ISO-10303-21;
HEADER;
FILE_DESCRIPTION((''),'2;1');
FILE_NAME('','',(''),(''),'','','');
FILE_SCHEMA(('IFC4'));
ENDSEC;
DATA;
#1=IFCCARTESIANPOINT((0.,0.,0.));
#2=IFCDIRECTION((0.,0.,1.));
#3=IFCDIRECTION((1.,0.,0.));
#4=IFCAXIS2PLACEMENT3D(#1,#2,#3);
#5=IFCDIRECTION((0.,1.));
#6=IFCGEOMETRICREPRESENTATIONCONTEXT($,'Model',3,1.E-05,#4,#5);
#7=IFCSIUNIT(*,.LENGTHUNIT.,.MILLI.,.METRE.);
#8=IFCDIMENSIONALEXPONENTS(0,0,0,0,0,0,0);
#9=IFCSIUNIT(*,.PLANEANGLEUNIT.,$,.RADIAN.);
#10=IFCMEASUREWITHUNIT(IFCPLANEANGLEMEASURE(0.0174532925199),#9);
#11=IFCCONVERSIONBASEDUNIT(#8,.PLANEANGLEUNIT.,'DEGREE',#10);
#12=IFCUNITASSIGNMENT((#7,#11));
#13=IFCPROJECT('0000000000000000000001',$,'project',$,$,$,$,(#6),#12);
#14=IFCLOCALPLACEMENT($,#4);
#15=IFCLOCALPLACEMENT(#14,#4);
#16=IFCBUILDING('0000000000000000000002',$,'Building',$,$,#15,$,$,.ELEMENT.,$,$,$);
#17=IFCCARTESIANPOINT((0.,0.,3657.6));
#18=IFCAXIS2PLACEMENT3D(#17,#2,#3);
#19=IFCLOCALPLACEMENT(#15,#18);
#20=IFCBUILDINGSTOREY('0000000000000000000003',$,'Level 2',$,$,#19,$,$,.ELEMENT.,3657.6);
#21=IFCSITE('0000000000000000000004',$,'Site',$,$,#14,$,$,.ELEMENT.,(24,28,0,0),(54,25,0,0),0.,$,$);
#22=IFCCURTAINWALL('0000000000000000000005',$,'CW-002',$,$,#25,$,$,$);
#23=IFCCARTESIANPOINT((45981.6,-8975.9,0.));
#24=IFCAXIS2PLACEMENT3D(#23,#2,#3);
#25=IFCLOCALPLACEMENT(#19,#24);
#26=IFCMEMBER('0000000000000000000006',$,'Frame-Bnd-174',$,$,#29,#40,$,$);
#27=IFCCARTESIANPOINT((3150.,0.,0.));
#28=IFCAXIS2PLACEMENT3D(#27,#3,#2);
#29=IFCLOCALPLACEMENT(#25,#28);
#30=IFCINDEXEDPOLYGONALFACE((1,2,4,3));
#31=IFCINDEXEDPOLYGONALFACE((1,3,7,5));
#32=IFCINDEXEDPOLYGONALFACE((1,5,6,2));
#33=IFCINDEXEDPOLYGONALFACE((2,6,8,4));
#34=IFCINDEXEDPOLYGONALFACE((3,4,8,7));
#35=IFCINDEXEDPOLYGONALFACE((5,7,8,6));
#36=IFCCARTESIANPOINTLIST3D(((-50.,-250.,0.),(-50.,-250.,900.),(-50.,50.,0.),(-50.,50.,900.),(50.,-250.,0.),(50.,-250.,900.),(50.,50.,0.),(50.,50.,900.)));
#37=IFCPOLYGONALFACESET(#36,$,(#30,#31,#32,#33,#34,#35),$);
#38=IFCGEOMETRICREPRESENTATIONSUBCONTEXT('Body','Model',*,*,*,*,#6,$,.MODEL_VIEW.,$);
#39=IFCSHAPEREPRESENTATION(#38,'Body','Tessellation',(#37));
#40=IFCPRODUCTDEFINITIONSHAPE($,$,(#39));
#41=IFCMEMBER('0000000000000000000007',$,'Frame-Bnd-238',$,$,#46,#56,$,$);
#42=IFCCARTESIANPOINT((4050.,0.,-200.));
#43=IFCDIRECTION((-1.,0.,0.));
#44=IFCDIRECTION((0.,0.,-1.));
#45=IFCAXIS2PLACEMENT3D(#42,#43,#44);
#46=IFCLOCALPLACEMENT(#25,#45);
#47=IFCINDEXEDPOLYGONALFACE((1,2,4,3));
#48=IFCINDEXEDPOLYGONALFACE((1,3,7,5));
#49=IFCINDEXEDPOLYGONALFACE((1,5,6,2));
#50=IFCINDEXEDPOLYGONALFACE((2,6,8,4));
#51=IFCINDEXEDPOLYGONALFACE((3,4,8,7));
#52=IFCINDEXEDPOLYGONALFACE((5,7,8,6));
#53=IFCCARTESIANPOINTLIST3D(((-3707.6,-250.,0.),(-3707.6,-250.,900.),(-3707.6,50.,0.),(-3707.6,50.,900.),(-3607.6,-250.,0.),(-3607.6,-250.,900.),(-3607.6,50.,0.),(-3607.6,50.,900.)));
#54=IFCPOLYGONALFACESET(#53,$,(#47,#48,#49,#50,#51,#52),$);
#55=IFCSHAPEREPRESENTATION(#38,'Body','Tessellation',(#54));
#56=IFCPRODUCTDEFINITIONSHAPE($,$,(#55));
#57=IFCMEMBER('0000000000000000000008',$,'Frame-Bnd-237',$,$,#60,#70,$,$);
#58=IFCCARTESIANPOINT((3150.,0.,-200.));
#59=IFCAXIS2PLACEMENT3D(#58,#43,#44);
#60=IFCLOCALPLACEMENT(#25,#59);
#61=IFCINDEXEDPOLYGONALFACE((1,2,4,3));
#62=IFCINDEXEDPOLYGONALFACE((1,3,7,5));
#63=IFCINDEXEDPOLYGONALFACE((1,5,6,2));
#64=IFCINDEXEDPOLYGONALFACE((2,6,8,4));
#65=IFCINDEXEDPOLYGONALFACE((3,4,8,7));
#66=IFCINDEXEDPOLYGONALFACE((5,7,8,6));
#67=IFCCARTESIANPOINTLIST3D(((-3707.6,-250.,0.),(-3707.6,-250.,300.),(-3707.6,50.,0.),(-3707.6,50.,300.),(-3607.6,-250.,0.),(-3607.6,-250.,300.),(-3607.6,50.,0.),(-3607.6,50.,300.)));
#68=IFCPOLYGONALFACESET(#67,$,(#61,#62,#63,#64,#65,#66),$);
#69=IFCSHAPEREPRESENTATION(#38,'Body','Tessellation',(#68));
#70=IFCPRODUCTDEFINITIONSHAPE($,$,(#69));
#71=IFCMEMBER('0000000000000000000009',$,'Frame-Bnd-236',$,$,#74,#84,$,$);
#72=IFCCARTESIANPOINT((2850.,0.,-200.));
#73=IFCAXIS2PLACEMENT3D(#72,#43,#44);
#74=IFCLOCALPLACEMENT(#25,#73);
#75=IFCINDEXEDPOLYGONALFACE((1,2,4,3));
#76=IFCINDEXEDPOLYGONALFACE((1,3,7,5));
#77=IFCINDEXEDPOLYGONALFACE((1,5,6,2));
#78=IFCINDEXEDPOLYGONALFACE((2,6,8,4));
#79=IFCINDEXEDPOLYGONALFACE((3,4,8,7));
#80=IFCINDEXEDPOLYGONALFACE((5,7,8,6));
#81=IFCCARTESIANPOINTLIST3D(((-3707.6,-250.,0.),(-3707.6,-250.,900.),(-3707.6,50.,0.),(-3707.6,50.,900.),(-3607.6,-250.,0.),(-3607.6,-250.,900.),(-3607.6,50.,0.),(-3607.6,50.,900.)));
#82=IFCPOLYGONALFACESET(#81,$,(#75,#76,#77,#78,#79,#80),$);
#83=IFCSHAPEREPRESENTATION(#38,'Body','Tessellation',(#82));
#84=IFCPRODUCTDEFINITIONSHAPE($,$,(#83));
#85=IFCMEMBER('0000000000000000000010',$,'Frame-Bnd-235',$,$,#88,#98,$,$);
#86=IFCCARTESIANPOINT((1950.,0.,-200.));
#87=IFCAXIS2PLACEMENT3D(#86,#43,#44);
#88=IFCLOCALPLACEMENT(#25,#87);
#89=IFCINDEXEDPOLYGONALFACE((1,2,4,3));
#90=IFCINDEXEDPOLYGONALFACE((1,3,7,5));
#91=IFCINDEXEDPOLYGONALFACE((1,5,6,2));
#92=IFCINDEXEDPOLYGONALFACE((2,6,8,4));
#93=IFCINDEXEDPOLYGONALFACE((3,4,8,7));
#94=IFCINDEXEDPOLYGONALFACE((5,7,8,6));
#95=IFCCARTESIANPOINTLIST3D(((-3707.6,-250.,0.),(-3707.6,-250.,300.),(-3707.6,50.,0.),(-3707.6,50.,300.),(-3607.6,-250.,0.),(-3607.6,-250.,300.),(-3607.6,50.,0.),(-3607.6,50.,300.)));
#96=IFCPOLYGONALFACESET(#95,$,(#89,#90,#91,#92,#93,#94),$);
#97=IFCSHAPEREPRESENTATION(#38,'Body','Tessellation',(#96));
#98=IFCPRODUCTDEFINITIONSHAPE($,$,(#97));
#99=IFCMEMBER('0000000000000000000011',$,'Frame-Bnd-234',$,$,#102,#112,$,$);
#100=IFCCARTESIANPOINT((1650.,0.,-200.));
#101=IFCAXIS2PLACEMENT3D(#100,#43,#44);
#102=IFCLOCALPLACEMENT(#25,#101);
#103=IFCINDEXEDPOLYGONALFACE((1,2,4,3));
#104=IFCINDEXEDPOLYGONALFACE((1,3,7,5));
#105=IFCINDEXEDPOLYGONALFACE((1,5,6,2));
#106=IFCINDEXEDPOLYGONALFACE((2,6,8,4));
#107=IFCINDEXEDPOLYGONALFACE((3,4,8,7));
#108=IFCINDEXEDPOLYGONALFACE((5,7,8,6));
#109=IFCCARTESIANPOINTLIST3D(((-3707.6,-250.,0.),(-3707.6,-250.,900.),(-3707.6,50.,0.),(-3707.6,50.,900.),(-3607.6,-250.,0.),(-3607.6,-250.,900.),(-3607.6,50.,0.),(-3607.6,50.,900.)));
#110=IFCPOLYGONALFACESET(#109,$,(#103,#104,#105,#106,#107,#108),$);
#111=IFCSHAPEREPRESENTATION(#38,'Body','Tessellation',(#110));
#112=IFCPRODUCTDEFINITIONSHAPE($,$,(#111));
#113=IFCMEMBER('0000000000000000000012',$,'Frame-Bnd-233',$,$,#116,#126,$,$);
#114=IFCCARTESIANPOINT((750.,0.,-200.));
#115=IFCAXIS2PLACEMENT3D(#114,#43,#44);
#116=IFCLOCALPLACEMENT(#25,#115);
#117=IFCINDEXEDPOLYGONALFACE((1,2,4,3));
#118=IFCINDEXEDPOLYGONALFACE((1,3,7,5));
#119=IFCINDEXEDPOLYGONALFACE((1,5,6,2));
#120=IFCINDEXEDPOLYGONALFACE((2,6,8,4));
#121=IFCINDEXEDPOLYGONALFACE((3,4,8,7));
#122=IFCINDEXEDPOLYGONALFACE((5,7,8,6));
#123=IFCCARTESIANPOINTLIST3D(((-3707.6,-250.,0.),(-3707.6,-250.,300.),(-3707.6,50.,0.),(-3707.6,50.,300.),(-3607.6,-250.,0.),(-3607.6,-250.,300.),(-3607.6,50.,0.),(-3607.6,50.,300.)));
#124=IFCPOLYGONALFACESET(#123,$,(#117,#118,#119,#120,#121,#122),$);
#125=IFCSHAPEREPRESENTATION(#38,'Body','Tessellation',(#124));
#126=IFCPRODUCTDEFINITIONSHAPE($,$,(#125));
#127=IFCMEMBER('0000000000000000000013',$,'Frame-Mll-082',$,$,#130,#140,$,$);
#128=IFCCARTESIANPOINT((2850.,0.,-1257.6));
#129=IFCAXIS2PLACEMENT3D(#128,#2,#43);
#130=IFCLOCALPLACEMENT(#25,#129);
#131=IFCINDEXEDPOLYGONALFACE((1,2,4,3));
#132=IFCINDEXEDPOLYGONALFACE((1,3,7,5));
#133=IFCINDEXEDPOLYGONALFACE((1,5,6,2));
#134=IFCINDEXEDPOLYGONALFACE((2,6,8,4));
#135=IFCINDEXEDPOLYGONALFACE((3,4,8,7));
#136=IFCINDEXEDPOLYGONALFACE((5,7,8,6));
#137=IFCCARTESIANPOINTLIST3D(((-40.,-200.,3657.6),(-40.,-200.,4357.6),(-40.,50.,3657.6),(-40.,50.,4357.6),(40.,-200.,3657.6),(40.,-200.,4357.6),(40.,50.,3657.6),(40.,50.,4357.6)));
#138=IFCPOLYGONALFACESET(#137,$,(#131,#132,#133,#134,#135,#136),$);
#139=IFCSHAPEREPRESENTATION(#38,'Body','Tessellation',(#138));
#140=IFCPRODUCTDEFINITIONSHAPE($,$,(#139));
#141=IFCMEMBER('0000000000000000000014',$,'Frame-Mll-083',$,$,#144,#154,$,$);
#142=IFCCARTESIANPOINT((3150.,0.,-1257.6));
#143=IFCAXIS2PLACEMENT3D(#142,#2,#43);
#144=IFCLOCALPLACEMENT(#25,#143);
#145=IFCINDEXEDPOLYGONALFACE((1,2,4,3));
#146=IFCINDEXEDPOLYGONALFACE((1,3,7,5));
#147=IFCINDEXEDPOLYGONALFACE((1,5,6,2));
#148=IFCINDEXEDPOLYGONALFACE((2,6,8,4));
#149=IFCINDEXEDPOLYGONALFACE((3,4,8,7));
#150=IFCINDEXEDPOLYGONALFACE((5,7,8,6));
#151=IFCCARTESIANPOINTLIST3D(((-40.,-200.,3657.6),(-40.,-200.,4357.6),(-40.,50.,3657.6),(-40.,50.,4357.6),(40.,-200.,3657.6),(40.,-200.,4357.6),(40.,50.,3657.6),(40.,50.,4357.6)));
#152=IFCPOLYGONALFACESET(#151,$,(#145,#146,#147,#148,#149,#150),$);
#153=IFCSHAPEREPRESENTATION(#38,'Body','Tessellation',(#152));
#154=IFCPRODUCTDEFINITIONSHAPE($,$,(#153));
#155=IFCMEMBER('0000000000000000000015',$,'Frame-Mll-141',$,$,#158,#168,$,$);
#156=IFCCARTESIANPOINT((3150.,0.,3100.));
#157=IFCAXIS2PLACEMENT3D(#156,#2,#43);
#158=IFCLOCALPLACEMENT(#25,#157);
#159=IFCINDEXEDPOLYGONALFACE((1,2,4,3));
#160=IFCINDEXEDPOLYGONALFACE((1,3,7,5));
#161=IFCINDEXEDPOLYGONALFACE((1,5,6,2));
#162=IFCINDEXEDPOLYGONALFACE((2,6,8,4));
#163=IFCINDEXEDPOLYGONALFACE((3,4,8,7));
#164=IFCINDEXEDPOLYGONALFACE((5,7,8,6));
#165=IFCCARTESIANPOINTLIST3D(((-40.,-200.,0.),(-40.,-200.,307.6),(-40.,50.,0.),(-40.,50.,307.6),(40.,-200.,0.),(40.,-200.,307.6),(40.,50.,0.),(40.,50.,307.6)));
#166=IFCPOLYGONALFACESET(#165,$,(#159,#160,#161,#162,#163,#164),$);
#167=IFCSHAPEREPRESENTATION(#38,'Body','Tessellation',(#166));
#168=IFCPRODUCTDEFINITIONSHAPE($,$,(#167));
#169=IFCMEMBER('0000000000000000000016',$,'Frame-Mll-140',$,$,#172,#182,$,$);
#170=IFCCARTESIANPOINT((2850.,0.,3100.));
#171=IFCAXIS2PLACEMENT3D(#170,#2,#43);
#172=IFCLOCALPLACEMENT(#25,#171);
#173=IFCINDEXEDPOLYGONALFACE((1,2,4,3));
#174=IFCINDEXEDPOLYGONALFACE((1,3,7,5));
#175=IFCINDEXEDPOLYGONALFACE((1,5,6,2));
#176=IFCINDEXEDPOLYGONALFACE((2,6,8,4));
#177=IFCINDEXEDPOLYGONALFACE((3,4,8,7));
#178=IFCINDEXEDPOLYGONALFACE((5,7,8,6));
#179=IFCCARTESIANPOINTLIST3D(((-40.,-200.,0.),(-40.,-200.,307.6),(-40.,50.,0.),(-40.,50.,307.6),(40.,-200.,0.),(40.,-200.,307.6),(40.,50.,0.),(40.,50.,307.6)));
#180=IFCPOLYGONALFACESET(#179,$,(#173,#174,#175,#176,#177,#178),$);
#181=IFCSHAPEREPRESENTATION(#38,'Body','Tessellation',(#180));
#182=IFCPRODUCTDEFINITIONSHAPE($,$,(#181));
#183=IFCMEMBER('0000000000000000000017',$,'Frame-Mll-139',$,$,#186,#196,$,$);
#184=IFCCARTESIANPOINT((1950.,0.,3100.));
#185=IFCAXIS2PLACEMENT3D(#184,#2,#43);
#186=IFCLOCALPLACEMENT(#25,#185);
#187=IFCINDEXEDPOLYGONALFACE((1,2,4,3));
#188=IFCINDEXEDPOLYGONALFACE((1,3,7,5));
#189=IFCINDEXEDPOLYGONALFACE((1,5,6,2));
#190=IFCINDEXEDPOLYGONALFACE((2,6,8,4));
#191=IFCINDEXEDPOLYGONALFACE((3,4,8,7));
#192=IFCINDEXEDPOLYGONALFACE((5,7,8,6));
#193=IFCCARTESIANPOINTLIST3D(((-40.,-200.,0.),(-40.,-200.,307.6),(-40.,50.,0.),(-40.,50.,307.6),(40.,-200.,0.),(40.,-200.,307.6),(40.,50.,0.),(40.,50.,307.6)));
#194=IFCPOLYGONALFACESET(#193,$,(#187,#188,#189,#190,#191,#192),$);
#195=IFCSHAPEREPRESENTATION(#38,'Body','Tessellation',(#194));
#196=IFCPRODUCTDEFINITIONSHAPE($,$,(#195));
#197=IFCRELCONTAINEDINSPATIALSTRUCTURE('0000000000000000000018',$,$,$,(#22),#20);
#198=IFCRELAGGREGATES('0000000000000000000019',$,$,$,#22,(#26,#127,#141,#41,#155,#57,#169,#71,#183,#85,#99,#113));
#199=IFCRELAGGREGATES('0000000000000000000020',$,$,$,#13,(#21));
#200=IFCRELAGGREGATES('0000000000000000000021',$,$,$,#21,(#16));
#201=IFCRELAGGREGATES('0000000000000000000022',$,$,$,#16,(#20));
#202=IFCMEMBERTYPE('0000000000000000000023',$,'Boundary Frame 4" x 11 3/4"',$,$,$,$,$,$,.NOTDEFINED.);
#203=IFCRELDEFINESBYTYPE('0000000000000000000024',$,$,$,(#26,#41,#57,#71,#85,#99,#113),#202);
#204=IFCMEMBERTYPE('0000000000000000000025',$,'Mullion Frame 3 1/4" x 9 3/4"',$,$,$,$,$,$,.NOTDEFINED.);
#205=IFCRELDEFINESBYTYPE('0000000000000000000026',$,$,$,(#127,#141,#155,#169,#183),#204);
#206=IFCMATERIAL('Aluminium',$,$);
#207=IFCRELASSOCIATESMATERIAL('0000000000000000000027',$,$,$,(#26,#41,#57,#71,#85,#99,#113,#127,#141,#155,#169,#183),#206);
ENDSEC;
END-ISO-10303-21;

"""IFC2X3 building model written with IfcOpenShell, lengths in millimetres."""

from ifc_helpers import new_model, entity, si_unit, converted_unit, direction, frame, origin_with_axes, place, context, subcontext, project, spatial, polyline, outline, extrude, material, type_object, element, aggregate, save


model = new_model("IFC2X3")

# Units and contexts
model_context = context("Model", 3, precision=1e-05, world=origin_with_axes(), true_north=direction((0.0, 1.0)))
body_context = subcontext(model_context, "Body", "Model", "MODEL_VIEW")
ifc_project = project(units=[si_unit("LENGTHUNIT", "METRE", prefix="MILLI"), converted_unit("PLANEANGLEUNIT", "DEGREE", entity("IfcPlaneAngleMeasure", 0.0174532925199), si_unit("PLANEANGLEUNIT", "RADIAN"), dimensions=[0, 0, 0, 0, 0, 0, 0])], contexts=[model_context])

# Site, building, storey
site_placement = place(None, origin_with_axes())
site = spatial("IfcSite", under=ifc_project, at=site_placement, Name="Site", CompositionType="ELEMENT", RefLatitude=(24, 28, 0, 0), RefLongitude=(54, 25, 0, 0), RefElevation=0.0)
building_placement = place(site_placement, origin_with_axes())
building = spatial("IfcBuilding", under=site, at=building_placement, Name="Building", CompositionType="ELEMENT")
storey_placement = place(building_placement, frame((0.0, 0.0, 3657.6), z_axis=(0.0, 0.0, 1.0), x_axis=(1.0, 0.0, 0.0)))
storey = spatial("IfcBuildingStorey", under=building, at=storey_placement, Name="Level 2", CompositionType="ELEMENT", Elevation=3657.6)

# Curtain wall, members
curtain_wall_placement = place(storey_placement, frame((45981.6, -8975.9, 0.0), z_axis=(0.0, 0.0, 1.0), x_axis=(1.0, 0.0, 0.0)))
curtain_wall = element("IfcCurtainWall", 1, at=curtain_wall_placement, inside=storey, Name="CW-002")
ifc_material_1 = material(Name="Aluminium")
member_type_1 = type_object("IfcMemberType", Name="Boundary Frame 4\" x 11 3/4\"", PredefinedType="NOTDEFINED")
member_1_placement = place(curtain_wall_placement, frame((3150.0, 0.0, 0.0), z_axis=(1.0, 0.0, 0.0), x_axis=(0.0, 0.0, 1.0)))
member_1 = element("IfcMember", 2, at=member_1_placement, type_object=member_type_1, material=ifc_material_1, Name="Frame-Bnd-174", context=body_context, shape_type="SweptSolid", body=[
    extrude(outline(polyline([(-250.0, -50.0), (50.0, -50.0), (50.0, 50.0), (-250.0, 50.0), (-250.0, -50.0)])), frame((0.0, 0.0, 0.0), z_axis=(0.0, 0.0, 1.0), x_axis=(0.0, 1.0, 0.0)), (0.0, 0.0, 1.0), 900.0),
])
member_2_placement = place(curtain_wall_placement, frame((4050.0, 0.0, -200.0), z_axis=(-1.0, 0.0, 0.0), x_axis=(0.0, 0.0, -1.0)))
member_2 = element("IfcMember", 3, at=member_2_placement, type_object=member_type_1, material=ifc_material_1, Name="Frame-Bnd-238", context=body_context, shape_type="SweptSolid", body=[
    extrude(outline(polyline([(250.0, -3607.6), (-50.0, -3607.6), (-50.0, -3707.6), (250.0, -3707.6), (250.0, -3607.6)])), frame((0.0, 0.0, 0.0), z_axis=(0.0, 0.0, 1.0), x_axis=(0.0, -1.0, 0.0)), (0.0, 0.0, 1.0), 900.0),
])
member_3_placement = place(curtain_wall_placement, frame((3150.0, 0.0, -200.0), z_axis=(-1.0, 0.0, 0.0), x_axis=(0.0, 0.0, -1.0)))
member_3 = element("IfcMember", 4, at=member_3_placement, type_object=member_type_1, material=ifc_material_1, Name="Frame-Bnd-237", context=body_context, shape_type="SweptSolid", body=[
    extrude(outline(polyline([(250.0, -3607.6), (-50.0, -3607.6), (-50.0, -3707.6), (250.0, -3707.6), (250.0, -3607.6)])), frame((0.0, 0.0, 0.0), z_axis=(0.0, 0.0, 1.0), x_axis=(0.0, -1.0, 0.0)), (0.0, 0.0, 1.0), 300.0),
])
member_4_placement = place(curtain_wall_placement, frame((2850.0, 0.0, -200.0), z_axis=(-1.0, 0.0, 0.0), x_axis=(0.0, 0.0, -1.0)))
member_4 = element("IfcMember", 5, at=member_4_placement, type_object=member_type_1, material=ifc_material_1, Name="Frame-Bnd-236", context=body_context, shape_type="SweptSolid", body=[
    extrude(outline(polyline([(250.0, -3607.6), (-50.0, -3607.6), (-50.0, -3707.6), (250.0, -3707.6), (250.0, -3607.6)])), frame((0.0, 0.0, 0.0), z_axis=(0.0, 0.0, 1.0), x_axis=(0.0, -1.0, 0.0)), (0.0, 0.0, 1.0), 900.0),
])
member_5_placement = place(curtain_wall_placement, frame((1950.0, 0.0, -200.0), z_axis=(-1.0, 0.0, 0.0), x_axis=(0.0, 0.0, -1.0)))
member_5 = element("IfcMember", 6, at=member_5_placement, type_object=member_type_1, material=ifc_material_1, Name="Frame-Bnd-235", context=body_context, shape_type="SweptSolid", body=[
    extrude(outline(polyline([(250.0, -3607.6), (-50.0, -3607.6), (-50.0, -3707.6), (250.0, -3707.6), (250.0, -3607.6)])), frame((0.0, 0.0, 0.0), z_axis=(0.0, 0.0, 1.0), x_axis=(0.0, -1.0, 0.0)), (0.0, 0.0, 1.0), 300.0),
])
member_6_placement = place(curtain_wall_placement, frame((1650.0, 0.0, -200.0), z_axis=(-1.0, 0.0, 0.0), x_axis=(0.0, 0.0, -1.0)))
member_6 = element("IfcMember", 7, at=member_6_placement, type_object=member_type_1, material=ifc_material_1, Name="Frame-Bnd-234", context=body_context, shape_type="SweptSolid", body=[
    extrude(outline(polyline([(250.0, -3607.6), (-50.0, -3607.6), (-50.0, -3707.6), (250.0, -3707.6), (250.0, -3607.6)])), frame((0.0, 0.0, 0.0), z_axis=(0.0, 0.0, 1.0), x_axis=(0.0, -1.0, 0.0)), (0.0, 0.0, 1.0), 900.0),
])
member_7_placement = place(curtain_wall_placement, frame((750.0, 0.0, -200.0), z_axis=(-1.0, 0.0, 0.0), x_axis=(0.0, 0.0, -1.0)))
member_7 = element("IfcMember", 8, at=member_7_placement, type_object=member_type_1, material=ifc_material_1, Name="Frame-Bnd-233", context=body_context, shape_type="SweptSolid", body=[
    extrude(outline(polyline([(250.0, -3607.6), (-50.0, -3607.6), (-50.0, -3707.6), (250.0, -3707.6), (250.0, -3607.6)])), frame((0.0, 0.0, 0.0), z_axis=(0.0, 0.0, 1.0), x_axis=(0.0, -1.0, 0.0)), (0.0, 0.0, 1.0), 300.0),
])
member_type_2 = type_object("IfcMemberType", Name="Mullion Frame 3 1/4\" x 9 3/4\"", PredefinedType="NOTDEFINED")
member_8_placement = place(curtain_wall_placement, frame((2850.0, 0.0, -1257.6), z_axis=(0.0, 0.0, 1.0), x_axis=(-1.0, 0.0, 0.0)))
member_8 = element("IfcMember", 9, at=member_8_placement, type_object=member_type_2, material=ifc_material_1, Name="Frame-Mll-082", context=body_context, shape_type="SweptSolid", body=[
    extrude(outline(polyline([(-40.0, 200.0), (-40.0, -50.0), (40.0, -50.0), (40.0, 200.0), (-40.0, 200.0)])), frame((0.0, 0.0, 3657.6), z_axis=(0.0, 0.0, 1.0), x_axis=(-1.0, 0.0, 0.0)), (0.0, 0.0, 1.0), 700.0),
])
member_9_placement = place(curtain_wall_placement, frame((3150.0, 0.0, -1257.6), z_axis=(0.0, 0.0, 1.0), x_axis=(-1.0, 0.0, 0.0)))
member_9 = element("IfcMember", 10, at=member_9_placement, type_object=member_type_2, material=ifc_material_1, Name="Frame-Mll-083", context=body_context, shape_type="SweptSolid", body=[
    extrude(outline(polyline([(-40.0, 200.0), (-40.0, -50.0), (40.0, -50.0), (40.0, 200.0), (-40.0, 200.0)])), frame((0.0, 0.0, 3657.6), z_axis=(0.0, 0.0, 1.0), x_axis=(-1.0, 0.0, 0.0)), (0.0, 0.0, 1.0), 700.0),
])
member_10_placement = place(curtain_wall_placement, frame((3150.0, 0.0, 3100.0), z_axis=(0.0, 0.0, 1.0), x_axis=(-1.0, 0.0, 0.0)))
member_10 = element("IfcMember", 11, at=member_10_placement, type_object=member_type_2, material=ifc_material_1, Name="Frame-Mll-141", context=body_context, shape_type="SweptSolid", body=[
    extrude(outline(polyline([(-40.0, 200.0), (-40.0, -50.0), (40.0, -50.0), (40.0, 200.0), (-40.0, 200.0)])), frame((0.0, 0.0, 0.0), z_axis=(0.0, 0.0, 1.0), x_axis=(-1.0, 0.0, 0.0)), (0.0, 0.0, 1.0), 307.6),
])
member_11_placement = place(curtain_wall_placement, frame((2850.0, 0.0, 3100.0), z_axis=(0.0, 0.0, 1.0), x_axis=(-1.0, 0.0, 0.0)))
member_11 = element("IfcMember", 12, at=member_11_placement, type_object=member_type_2, material=ifc_material_1, Name="Frame-Mll-140", context=body_context, shape_type="SweptSolid", body=[
    extrude(outline(polyline([(-40.0, 200.0), (-40.0, -50.0), (40.0, -50.0), (40.0, 200.0), (-40.0, 200.0)])), frame((0.0, 0.0, 0.0), z_axis=(0.0, 0.0, 1.0), x_axis=(-1.0, 0.0, 0.0)), (0.0, 0.0, 1.0), 307.6),
])
member_12_placement = place(curtain_wall_placement, frame((1950.0, 0.0, 3100.0), z_axis=(0.0, 0.0, 1.0), x_axis=(-1.0, 0.0, 0.0)))
member_12 = element("IfcMember", 13, at=member_12_placement, type_object=member_type_2, material=ifc_material_1, Name="Frame-Mll-139", context=body_context, shape_type="SweptSolid", body=[
    extrude(outline(polyline([(-40.0, 200.0), (-40.0, -50.0), (40.0, -50.0), (40.0, 200.0), (-40.0, 200.0)])), frame((0.0, 0.0, 0.0), z_axis=(0.0, 0.0, 1.0), x_axis=(-1.0, 0.0, 0.0)), (0.0, 0.0, 1.0), 307.6),
])
aggregate(curtain_wall, [member_1, member_8, member_9, member_2, member_10, member_3, member_11, member_4, member_12, member_5, member_6, member_7])

save(model, "model.ifc")
